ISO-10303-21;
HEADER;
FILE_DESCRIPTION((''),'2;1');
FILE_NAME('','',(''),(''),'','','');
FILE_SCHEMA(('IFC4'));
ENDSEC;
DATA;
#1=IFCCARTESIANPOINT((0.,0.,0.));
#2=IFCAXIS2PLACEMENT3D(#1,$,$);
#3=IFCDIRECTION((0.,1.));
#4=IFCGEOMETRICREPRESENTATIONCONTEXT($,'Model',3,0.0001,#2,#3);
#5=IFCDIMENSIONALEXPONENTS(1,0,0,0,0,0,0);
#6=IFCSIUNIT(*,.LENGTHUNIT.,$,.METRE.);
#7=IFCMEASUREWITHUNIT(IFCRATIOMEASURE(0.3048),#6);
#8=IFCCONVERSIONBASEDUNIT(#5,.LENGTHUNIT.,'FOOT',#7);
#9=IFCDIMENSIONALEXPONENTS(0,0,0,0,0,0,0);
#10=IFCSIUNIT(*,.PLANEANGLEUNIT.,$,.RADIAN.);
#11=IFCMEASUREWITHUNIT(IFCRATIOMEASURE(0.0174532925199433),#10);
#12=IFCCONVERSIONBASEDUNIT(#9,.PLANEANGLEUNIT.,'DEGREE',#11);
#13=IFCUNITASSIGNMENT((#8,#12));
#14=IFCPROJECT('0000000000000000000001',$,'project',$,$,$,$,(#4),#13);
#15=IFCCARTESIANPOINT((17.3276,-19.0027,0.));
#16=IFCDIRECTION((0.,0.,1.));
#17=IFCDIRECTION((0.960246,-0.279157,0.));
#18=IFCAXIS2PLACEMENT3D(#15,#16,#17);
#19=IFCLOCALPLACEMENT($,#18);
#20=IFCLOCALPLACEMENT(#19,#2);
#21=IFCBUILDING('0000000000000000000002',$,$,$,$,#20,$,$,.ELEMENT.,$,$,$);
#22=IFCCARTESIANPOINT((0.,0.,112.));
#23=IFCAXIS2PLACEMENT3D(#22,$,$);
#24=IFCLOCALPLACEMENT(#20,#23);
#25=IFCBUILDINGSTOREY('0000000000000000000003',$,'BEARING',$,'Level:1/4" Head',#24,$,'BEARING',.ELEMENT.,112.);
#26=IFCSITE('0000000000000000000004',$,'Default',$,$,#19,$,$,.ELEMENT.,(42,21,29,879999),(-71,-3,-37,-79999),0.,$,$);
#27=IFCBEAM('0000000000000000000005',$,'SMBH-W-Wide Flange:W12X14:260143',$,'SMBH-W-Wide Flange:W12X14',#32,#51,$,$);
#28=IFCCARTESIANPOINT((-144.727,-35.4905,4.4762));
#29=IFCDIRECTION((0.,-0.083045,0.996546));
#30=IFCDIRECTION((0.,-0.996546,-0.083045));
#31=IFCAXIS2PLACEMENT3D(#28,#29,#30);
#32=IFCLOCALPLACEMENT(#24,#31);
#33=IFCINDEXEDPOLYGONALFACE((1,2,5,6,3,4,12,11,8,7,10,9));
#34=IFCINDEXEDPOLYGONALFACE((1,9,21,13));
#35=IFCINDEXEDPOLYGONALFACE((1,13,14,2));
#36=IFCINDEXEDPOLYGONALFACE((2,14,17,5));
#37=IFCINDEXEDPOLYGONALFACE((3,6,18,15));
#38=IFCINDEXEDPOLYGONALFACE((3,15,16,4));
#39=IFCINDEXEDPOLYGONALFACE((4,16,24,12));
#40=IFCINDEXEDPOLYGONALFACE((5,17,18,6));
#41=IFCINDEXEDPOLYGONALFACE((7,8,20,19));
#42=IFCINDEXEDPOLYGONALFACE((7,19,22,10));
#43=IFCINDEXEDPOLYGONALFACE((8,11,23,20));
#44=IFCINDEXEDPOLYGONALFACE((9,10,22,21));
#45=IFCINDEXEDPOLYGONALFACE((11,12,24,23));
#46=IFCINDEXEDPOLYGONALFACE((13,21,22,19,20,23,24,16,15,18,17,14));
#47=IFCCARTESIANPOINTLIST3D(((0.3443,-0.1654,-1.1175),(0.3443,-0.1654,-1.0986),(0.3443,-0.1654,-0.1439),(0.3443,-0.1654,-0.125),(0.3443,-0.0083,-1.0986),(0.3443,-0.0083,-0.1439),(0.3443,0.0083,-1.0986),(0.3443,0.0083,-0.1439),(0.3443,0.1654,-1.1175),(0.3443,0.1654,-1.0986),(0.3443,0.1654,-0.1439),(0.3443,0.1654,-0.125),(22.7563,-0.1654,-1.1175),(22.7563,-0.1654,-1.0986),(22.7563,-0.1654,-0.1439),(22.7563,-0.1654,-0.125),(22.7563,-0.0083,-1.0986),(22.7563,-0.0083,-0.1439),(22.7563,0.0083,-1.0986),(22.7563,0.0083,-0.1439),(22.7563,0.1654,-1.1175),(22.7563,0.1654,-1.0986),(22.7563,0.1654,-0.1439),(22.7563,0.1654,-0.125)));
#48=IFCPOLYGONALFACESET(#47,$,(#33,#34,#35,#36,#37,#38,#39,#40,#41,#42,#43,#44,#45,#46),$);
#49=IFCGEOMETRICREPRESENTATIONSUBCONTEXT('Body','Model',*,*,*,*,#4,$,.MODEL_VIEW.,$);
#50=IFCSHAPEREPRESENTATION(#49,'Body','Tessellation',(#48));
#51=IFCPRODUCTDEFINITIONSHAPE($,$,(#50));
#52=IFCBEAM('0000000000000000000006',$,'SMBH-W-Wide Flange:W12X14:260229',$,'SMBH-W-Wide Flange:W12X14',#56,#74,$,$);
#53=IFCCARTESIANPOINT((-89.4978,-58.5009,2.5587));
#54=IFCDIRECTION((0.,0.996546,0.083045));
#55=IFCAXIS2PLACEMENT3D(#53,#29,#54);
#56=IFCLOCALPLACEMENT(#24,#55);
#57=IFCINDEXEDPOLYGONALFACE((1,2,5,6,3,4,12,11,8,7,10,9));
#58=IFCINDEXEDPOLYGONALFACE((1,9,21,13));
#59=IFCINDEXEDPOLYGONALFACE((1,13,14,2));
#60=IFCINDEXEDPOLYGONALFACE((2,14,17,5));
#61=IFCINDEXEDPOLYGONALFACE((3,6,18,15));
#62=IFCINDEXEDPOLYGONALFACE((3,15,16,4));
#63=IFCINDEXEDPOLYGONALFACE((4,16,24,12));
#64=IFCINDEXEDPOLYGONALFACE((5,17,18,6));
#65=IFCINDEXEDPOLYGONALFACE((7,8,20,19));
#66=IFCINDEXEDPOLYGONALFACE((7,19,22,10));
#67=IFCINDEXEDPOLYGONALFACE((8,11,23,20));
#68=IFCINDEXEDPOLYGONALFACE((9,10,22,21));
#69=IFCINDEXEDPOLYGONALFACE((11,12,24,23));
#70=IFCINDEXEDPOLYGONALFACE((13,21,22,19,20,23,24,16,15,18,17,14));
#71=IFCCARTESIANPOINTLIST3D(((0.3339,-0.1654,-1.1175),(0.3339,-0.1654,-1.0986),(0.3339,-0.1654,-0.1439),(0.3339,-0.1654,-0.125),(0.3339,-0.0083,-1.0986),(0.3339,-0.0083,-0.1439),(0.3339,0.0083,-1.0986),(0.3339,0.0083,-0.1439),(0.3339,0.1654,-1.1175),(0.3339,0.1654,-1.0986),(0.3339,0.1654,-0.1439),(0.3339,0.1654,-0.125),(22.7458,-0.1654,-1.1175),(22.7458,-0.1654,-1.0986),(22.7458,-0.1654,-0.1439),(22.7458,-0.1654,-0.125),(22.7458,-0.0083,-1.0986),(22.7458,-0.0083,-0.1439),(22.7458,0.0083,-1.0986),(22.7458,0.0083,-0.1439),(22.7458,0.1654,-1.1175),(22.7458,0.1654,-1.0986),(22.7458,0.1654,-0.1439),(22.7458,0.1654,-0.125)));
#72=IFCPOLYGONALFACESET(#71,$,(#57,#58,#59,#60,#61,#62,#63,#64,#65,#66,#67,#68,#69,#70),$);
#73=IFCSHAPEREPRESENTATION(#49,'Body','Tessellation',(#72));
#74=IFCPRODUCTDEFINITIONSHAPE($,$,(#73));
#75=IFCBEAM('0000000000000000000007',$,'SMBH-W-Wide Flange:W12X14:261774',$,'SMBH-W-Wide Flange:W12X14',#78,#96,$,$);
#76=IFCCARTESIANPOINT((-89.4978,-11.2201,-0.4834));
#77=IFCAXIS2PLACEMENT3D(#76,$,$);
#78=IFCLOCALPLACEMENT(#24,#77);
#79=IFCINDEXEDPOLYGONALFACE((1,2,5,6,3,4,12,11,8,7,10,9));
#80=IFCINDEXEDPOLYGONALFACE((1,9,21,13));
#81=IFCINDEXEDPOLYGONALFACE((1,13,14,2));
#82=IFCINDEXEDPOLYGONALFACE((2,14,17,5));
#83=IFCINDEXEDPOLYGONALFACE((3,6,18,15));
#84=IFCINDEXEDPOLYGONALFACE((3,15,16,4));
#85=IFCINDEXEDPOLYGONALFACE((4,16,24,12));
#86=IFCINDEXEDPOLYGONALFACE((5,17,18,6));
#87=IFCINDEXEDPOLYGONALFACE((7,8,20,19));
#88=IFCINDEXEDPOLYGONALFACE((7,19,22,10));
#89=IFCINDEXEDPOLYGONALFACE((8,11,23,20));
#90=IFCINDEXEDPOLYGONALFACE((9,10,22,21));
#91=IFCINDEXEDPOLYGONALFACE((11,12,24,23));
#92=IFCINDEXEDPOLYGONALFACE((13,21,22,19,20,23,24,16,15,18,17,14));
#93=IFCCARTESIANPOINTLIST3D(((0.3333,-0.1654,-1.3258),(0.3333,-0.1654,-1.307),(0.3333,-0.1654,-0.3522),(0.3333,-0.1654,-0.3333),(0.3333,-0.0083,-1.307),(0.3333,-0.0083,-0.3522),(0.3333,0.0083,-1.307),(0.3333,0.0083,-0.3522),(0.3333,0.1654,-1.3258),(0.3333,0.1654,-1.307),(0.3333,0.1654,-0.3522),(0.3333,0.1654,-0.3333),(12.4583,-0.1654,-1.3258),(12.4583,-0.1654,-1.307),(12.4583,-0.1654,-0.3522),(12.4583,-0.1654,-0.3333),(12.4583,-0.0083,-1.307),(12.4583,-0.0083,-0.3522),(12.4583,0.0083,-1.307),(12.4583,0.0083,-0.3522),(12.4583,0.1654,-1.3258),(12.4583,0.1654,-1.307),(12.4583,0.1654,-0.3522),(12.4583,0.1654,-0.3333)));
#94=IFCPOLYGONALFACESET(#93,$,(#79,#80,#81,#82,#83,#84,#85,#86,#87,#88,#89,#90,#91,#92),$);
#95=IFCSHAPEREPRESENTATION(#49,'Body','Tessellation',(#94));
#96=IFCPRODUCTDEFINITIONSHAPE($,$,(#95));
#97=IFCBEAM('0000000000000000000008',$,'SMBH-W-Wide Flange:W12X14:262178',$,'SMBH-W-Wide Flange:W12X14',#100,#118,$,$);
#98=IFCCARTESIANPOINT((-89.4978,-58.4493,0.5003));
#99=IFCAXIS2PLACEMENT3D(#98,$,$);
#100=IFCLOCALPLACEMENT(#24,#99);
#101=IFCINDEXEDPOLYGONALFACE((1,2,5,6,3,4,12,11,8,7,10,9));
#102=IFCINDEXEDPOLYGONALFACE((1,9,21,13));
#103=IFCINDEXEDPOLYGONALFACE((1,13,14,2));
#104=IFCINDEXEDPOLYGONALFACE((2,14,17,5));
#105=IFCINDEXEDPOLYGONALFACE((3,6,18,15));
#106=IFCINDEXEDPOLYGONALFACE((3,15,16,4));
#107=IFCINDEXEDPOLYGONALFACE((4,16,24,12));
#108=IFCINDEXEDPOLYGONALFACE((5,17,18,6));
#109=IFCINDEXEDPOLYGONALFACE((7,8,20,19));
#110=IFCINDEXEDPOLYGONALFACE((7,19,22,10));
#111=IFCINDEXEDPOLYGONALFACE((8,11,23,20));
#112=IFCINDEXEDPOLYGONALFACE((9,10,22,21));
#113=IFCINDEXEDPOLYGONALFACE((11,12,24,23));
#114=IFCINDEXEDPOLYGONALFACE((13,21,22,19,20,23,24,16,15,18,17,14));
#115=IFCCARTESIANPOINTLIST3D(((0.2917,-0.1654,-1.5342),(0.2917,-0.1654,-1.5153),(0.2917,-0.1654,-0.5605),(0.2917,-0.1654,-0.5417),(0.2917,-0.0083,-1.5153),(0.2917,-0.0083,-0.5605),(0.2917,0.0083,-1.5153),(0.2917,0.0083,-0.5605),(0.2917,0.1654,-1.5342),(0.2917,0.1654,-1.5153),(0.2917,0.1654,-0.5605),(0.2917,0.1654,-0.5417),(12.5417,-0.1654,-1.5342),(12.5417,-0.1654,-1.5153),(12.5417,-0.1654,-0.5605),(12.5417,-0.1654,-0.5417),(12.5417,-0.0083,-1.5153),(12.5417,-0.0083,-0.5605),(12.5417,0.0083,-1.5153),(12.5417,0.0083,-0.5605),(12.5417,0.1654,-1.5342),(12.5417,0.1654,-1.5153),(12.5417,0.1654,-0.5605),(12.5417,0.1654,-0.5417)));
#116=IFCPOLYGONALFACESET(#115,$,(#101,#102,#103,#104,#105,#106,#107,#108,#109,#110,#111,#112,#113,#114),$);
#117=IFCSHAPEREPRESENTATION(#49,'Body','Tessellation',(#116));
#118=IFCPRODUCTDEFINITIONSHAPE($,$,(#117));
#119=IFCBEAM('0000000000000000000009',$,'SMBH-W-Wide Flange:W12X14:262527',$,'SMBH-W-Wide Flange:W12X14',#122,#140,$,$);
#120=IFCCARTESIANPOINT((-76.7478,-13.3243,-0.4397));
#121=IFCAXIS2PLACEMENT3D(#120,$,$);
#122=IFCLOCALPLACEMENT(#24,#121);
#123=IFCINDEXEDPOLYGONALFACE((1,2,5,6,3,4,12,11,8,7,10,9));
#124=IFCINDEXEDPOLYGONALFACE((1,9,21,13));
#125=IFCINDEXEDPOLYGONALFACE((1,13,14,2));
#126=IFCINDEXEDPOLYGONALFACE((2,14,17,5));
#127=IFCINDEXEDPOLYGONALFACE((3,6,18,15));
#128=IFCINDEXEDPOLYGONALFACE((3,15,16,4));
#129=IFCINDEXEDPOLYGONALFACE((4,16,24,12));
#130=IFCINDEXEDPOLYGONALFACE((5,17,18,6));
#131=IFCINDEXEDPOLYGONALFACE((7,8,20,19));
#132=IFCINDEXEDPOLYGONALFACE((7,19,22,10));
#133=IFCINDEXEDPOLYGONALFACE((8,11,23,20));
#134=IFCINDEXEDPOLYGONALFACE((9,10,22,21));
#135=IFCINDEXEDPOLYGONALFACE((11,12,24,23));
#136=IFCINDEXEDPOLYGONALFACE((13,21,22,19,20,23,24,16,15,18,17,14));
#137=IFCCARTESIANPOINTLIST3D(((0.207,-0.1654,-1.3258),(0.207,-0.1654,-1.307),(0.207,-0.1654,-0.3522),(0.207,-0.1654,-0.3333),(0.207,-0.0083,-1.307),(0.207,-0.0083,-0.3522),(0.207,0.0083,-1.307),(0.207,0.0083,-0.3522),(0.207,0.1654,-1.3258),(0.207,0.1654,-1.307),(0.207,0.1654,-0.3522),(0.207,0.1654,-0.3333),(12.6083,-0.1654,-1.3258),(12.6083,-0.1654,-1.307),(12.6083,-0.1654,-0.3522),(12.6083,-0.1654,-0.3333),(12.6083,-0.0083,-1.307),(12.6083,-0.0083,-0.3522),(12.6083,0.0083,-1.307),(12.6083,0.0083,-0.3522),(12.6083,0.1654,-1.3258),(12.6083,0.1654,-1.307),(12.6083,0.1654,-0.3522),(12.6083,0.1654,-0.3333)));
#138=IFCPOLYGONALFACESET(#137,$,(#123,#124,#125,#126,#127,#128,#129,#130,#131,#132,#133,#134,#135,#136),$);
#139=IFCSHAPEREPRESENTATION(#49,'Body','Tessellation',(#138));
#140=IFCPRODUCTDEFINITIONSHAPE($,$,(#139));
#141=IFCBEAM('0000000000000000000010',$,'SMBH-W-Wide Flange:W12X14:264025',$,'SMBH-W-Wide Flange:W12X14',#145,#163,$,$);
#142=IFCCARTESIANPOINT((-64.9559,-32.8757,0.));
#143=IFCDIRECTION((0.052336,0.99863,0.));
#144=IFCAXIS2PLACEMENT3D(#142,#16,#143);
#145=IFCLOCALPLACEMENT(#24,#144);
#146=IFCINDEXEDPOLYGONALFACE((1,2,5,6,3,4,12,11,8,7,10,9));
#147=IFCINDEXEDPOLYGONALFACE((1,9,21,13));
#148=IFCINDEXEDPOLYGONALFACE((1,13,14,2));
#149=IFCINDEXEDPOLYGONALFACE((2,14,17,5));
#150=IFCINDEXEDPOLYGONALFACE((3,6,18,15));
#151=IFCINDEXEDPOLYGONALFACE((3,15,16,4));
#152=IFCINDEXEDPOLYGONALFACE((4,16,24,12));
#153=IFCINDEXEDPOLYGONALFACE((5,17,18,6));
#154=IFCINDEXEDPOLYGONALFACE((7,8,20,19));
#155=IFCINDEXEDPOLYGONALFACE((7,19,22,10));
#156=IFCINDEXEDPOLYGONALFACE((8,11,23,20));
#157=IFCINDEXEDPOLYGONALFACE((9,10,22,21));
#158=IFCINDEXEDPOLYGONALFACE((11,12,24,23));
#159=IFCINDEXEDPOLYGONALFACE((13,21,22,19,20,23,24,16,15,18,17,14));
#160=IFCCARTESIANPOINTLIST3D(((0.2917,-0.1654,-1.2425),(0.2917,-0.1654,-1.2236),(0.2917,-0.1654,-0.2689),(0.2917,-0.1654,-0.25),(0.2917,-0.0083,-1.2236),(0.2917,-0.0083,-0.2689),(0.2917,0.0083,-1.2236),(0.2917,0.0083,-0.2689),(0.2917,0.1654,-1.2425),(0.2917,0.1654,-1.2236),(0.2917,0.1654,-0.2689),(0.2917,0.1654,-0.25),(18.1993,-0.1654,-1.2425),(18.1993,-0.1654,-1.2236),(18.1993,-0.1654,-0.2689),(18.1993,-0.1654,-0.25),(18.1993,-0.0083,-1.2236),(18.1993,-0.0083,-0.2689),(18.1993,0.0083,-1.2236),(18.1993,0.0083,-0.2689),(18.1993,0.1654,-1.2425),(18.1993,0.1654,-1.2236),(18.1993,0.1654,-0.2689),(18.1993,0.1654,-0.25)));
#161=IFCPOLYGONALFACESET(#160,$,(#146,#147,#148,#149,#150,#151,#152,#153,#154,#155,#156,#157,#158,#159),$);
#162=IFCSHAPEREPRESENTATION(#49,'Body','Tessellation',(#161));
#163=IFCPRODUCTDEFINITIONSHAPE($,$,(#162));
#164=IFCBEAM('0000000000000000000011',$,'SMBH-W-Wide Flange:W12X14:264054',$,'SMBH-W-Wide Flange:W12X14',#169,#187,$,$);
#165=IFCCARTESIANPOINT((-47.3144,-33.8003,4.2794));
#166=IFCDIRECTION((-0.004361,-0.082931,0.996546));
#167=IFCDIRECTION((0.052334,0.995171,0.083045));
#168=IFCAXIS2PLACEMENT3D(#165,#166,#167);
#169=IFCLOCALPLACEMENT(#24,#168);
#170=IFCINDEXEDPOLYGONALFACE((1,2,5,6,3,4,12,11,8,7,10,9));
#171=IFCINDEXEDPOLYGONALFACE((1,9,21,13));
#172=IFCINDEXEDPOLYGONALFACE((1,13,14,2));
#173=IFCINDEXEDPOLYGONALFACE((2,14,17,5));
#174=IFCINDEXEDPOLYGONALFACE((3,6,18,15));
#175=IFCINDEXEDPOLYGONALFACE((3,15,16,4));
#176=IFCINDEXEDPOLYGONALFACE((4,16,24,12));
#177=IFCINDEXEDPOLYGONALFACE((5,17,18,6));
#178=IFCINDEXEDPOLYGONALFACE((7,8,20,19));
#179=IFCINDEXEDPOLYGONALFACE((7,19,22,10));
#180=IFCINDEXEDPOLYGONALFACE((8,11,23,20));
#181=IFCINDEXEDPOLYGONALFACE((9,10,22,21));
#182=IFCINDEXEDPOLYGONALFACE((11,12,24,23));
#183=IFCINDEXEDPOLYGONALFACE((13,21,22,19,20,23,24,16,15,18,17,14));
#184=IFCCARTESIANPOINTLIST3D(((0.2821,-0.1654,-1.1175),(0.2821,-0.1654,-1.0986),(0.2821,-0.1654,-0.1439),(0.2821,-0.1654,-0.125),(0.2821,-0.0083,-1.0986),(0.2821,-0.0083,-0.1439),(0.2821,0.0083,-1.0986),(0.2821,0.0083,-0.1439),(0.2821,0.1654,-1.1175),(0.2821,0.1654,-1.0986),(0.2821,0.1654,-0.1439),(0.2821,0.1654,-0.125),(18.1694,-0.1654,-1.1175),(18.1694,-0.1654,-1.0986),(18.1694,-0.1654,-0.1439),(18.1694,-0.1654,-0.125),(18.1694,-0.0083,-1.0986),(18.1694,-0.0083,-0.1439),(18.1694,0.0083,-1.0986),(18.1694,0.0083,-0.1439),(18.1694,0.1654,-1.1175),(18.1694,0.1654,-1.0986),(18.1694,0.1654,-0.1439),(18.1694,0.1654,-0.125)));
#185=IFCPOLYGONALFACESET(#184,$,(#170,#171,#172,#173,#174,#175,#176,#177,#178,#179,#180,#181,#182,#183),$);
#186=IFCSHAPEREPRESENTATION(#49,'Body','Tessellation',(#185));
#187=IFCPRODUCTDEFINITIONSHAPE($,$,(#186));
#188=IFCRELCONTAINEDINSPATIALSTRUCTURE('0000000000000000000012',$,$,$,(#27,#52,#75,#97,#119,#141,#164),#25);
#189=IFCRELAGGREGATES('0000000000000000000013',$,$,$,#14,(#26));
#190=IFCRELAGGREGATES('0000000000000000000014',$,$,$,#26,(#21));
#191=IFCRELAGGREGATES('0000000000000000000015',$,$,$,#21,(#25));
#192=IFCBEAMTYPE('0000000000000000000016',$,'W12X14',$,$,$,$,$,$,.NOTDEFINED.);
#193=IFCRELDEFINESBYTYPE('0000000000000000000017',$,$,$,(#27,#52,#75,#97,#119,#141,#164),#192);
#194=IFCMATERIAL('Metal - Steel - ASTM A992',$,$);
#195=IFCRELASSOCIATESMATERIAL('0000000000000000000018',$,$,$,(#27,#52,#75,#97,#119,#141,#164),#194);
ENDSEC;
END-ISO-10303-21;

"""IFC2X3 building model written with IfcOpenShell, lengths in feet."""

from ifc_helpers import new_model, entity, si_unit, converted_unit, direction, frame, frame_2d, origin, place, context, subcontext, project, spatial, i_section, extrude, material, type_object, element, save


model = new_model("IFC2X3")

# Units and contexts
model_context = context("Model", 3, precision=0.0001, world=origin(), true_north=direction((0.0, 1.0)))
body_context = subcontext(model_context, "Body", "Model", "MODEL_VIEW")
ifc_project = project(units=[converted_unit("LENGTHUNIT", "FOOT", entity("IfcRatioMeasure", 0.3048), si_unit("LENGTHUNIT", "METRE"), dimensions=[1, 0, 0, 0, 0, 0, 0]), converted_unit("PLANEANGLEUNIT", "DEGREE", entity("IfcRatioMeasure", 0.0174532925199433), si_unit("PLANEANGLEUNIT", "RADIAN"), dimensions=[0, 0, 0, 0, 0, 0, 0])], contexts=[model_context])

# Site, building, storey
site_placement = place(None, frame((17.3276, -19.0027, 0.0), z_axis=(0.0, 0.0, 1.0), x_axis=(0.960246, -0.279157, 0.0)))
site = spatial("IfcSite", under=ifc_project, at=site_placement, Name="Default", CompositionType="ELEMENT", RefLatitude=(42, 21, 29, 879999), RefLongitude=(-71, -3, -37, -79999), RefElevation=0.0)
building_placement = place(site_placement, origin())
building = spatial("IfcBuilding", under=site, at=building_placement, CompositionType="ELEMENT")
storey_placement = place(building_placement, frame((0.0, 0.0, 112.0)))
storey = spatial("IfcBuildingStorey", under=building, at=storey_placement, Name="BEARING", ObjectType="Level:1/4\" Head", LongName="BEARING", CompositionType="ELEMENT", Elevation=112.0)

# Beams
ifc_material_1 = material(Name="Metal - Steel - ASTM A992")
beam_type_1 = type_object("IfcBeamType", Name="W12X14", PredefinedType="NOTDEFINED")
beam_1_placement = place(storey_placement, frame((-144.727, -35.4905, 4.4762), z_axis=(0.0, -0.083045, 0.996546), x_axis=(0.0, -0.996546, -0.083045)))
element("IfcBeam", 1, at=beam_1_placement, inside=storey, type_object=beam_type_1, material=ifc_material_1, Name="SMBH-W-Wide Flange:W12X14:260143", ObjectType="SMBH-W-Wide Flange:W12X14", context=body_context, shape_type="SweptSolid", body=[
    extrude(i_section(OverallWidth=0.3307, OverallDepth=0.9925, WebThickness=0.0166, FlangeThickness=0.0189, at=frame_2d((0.0, 0.0), x_axis=(0.0, 1.0))), frame((0.3443, 0.0, -0.6213), z_axis=(1.0, 0.0, 0.0), x_axis=(0.0, 0.0, -1.0)), (0.0, 0.0, 1.0), 22.4119),
])
beam_2_placement = place(storey_placement, frame((-89.4978, -58.5009, 2.5587), z_axis=(0.0, -0.083045, 0.996546), x_axis=(0.0, 0.996546, 0.083045)))
element("IfcBeam", 2, at=beam_2_placement, inside=storey, type_object=beam_type_1, material=ifc_material_1, Name="SMBH-W-Wide Flange:W12X14:260229", ObjectType="SMBH-W-Wide Flange:W12X14", context=body_context, shape_type="SweptSolid", body=[
    extrude(i_section(OverallWidth=0.3307, OverallDepth=0.9925, WebThickness=0.0166, FlangeThickness=0.0189, at=frame_2d((0.0, 0.0), x_axis=(0.0, 1.0))), frame((0.3339, 0.0, -0.6213), z_axis=(1.0, 0.0, 0.0), x_axis=(0.0, 0.0, -1.0)), (0.0, 0.0, 1.0), 22.4119),
])
beam_3_placement = place(storey_placement, frame((-89.4978, -11.2201, -0.4834)))
element("IfcBeam", 3, at=beam_3_placement, inside=storey, type_object=beam_type_1, material=ifc_material_1, Name="SMBH-W-Wide Flange:W12X14:261774", ObjectType="SMBH-W-Wide Flange:W12X14", context=body_context, shape_type="SweptSolid", body=[
    extrude(i_section(OverallWidth=0.3307, OverallDepth=0.9925, WebThickness=0.0166, FlangeThickness=0.0189, at=frame_2d((0.0, 0.0), x_axis=(0.0, 1.0))), frame((0.3333, 0.0, -0.8296), z_axis=(1.0, 0.0, 0.0), x_axis=(0.0, 0.0, -1.0)), (0.0, 0.0, 1.0), 12.125),
])
beam_4_placement = place(storey_placement, frame((-89.4978, -58.4493, 0.5003)))
element("IfcBeam", 4, at=beam_4_placement, inside=storey, type_object=beam_type_1, material=ifc_material_1, Name="SMBH-W-Wide Flange:W12X14:262178", ObjectType="SMBH-W-Wide Flange:W12X14", context=body_context, shape_type="SweptSolid", body=[
    extrude(i_section(OverallWidth=0.3307, OverallDepth=0.9925, WebThickness=0.0166, FlangeThickness=0.0189, at=frame_2d((0.0, 0.0), x_axis=(0.0, 1.0))), frame((0.2917, 0.0, -1.0379), z_axis=(1.0, 0.0, 0.0), x_axis=(0.0, 0.0, -1.0)), (0.0, 0.0, 1.0), 12.25),
])
beam_5_placement = place(storey_placement, frame((-76.7478, -13.3243, -0.4397)))
element("IfcBeam", 5, at=beam_5_placement, inside=storey, type_object=beam_type_1, material=ifc_material_1, Name="SMBH-W-Wide Flange:W12X14:262527", ObjectType="SMBH-W-Wide Flange:W12X14", context=body_context, shape_type="SweptSolid", body=[
    extrude(i_section(OverallWidth=0.3307, OverallDepth=0.9925, WebThickness=0.0166, FlangeThickness=0.0189, at=frame_2d((0.0, 0.0), x_axis=(0.0, 1.0))), frame((0.207, 0.0, -0.8296), z_axis=(1.0, 0.0, 0.0), x_axis=(0.0, 0.0, -1.0)), (0.0, 0.0, 1.0), 12.4012),
])
beam_6_placement = place(storey_placement, frame((-64.9559, -32.8757, 0.0), z_axis=(0.0, 0.0, 1.0), x_axis=(0.052336, 0.99863, 0.0)))
element("IfcBeam", 6, at=beam_6_placement, inside=storey, type_object=beam_type_1, material=ifc_material_1, Name="SMBH-W-Wide Flange:W12X14:264025", ObjectType="SMBH-W-Wide Flange:W12X14", context=body_context, shape_type="SweptSolid", body=[
    extrude(i_section(OverallWidth=0.3307, OverallDepth=0.9925, WebThickness=0.0166, FlangeThickness=0.0189, at=frame_2d((0.0, 0.0), x_axis=(0.0, 1.0))), frame((0.2917, 0.0, -0.7463), z_axis=(1.0, 0.0, 0.0), x_axis=(0.0, 0.0, -1.0)), (0.0, 0.0, 1.0), 17.9077),
])
beam_7_placement = place(storey_placement, frame((-47.3144, -33.8003, 4.2794), z_axis=(-0.004361, -0.082931, 0.996546), x_axis=(0.052334, 0.995171, 0.083045)))
element("IfcBeam", 7, at=beam_7_placement, inside=storey, type_object=beam_type_1, material=ifc_material_1, Name="SMBH-W-Wide Flange:W12X14:264054", ObjectType="SMBH-W-Wide Flange:W12X14", context=body_context, shape_type="SweptSolid", body=[
    extrude(i_section(OverallWidth=0.3307, OverallDepth=0.9925, WebThickness=0.0166, FlangeThickness=0.0189, at=frame_2d((0.0, 0.0), x_axis=(0.0, 1.0))), frame((0.2821, 0.0, -0.6213), z_axis=(1.0, 0.0, 0.0), x_axis=(0.0, 0.0, -1.0)), (0.0, 0.0, 1.0), 17.8872),
])

save(model, "model.ifc")
